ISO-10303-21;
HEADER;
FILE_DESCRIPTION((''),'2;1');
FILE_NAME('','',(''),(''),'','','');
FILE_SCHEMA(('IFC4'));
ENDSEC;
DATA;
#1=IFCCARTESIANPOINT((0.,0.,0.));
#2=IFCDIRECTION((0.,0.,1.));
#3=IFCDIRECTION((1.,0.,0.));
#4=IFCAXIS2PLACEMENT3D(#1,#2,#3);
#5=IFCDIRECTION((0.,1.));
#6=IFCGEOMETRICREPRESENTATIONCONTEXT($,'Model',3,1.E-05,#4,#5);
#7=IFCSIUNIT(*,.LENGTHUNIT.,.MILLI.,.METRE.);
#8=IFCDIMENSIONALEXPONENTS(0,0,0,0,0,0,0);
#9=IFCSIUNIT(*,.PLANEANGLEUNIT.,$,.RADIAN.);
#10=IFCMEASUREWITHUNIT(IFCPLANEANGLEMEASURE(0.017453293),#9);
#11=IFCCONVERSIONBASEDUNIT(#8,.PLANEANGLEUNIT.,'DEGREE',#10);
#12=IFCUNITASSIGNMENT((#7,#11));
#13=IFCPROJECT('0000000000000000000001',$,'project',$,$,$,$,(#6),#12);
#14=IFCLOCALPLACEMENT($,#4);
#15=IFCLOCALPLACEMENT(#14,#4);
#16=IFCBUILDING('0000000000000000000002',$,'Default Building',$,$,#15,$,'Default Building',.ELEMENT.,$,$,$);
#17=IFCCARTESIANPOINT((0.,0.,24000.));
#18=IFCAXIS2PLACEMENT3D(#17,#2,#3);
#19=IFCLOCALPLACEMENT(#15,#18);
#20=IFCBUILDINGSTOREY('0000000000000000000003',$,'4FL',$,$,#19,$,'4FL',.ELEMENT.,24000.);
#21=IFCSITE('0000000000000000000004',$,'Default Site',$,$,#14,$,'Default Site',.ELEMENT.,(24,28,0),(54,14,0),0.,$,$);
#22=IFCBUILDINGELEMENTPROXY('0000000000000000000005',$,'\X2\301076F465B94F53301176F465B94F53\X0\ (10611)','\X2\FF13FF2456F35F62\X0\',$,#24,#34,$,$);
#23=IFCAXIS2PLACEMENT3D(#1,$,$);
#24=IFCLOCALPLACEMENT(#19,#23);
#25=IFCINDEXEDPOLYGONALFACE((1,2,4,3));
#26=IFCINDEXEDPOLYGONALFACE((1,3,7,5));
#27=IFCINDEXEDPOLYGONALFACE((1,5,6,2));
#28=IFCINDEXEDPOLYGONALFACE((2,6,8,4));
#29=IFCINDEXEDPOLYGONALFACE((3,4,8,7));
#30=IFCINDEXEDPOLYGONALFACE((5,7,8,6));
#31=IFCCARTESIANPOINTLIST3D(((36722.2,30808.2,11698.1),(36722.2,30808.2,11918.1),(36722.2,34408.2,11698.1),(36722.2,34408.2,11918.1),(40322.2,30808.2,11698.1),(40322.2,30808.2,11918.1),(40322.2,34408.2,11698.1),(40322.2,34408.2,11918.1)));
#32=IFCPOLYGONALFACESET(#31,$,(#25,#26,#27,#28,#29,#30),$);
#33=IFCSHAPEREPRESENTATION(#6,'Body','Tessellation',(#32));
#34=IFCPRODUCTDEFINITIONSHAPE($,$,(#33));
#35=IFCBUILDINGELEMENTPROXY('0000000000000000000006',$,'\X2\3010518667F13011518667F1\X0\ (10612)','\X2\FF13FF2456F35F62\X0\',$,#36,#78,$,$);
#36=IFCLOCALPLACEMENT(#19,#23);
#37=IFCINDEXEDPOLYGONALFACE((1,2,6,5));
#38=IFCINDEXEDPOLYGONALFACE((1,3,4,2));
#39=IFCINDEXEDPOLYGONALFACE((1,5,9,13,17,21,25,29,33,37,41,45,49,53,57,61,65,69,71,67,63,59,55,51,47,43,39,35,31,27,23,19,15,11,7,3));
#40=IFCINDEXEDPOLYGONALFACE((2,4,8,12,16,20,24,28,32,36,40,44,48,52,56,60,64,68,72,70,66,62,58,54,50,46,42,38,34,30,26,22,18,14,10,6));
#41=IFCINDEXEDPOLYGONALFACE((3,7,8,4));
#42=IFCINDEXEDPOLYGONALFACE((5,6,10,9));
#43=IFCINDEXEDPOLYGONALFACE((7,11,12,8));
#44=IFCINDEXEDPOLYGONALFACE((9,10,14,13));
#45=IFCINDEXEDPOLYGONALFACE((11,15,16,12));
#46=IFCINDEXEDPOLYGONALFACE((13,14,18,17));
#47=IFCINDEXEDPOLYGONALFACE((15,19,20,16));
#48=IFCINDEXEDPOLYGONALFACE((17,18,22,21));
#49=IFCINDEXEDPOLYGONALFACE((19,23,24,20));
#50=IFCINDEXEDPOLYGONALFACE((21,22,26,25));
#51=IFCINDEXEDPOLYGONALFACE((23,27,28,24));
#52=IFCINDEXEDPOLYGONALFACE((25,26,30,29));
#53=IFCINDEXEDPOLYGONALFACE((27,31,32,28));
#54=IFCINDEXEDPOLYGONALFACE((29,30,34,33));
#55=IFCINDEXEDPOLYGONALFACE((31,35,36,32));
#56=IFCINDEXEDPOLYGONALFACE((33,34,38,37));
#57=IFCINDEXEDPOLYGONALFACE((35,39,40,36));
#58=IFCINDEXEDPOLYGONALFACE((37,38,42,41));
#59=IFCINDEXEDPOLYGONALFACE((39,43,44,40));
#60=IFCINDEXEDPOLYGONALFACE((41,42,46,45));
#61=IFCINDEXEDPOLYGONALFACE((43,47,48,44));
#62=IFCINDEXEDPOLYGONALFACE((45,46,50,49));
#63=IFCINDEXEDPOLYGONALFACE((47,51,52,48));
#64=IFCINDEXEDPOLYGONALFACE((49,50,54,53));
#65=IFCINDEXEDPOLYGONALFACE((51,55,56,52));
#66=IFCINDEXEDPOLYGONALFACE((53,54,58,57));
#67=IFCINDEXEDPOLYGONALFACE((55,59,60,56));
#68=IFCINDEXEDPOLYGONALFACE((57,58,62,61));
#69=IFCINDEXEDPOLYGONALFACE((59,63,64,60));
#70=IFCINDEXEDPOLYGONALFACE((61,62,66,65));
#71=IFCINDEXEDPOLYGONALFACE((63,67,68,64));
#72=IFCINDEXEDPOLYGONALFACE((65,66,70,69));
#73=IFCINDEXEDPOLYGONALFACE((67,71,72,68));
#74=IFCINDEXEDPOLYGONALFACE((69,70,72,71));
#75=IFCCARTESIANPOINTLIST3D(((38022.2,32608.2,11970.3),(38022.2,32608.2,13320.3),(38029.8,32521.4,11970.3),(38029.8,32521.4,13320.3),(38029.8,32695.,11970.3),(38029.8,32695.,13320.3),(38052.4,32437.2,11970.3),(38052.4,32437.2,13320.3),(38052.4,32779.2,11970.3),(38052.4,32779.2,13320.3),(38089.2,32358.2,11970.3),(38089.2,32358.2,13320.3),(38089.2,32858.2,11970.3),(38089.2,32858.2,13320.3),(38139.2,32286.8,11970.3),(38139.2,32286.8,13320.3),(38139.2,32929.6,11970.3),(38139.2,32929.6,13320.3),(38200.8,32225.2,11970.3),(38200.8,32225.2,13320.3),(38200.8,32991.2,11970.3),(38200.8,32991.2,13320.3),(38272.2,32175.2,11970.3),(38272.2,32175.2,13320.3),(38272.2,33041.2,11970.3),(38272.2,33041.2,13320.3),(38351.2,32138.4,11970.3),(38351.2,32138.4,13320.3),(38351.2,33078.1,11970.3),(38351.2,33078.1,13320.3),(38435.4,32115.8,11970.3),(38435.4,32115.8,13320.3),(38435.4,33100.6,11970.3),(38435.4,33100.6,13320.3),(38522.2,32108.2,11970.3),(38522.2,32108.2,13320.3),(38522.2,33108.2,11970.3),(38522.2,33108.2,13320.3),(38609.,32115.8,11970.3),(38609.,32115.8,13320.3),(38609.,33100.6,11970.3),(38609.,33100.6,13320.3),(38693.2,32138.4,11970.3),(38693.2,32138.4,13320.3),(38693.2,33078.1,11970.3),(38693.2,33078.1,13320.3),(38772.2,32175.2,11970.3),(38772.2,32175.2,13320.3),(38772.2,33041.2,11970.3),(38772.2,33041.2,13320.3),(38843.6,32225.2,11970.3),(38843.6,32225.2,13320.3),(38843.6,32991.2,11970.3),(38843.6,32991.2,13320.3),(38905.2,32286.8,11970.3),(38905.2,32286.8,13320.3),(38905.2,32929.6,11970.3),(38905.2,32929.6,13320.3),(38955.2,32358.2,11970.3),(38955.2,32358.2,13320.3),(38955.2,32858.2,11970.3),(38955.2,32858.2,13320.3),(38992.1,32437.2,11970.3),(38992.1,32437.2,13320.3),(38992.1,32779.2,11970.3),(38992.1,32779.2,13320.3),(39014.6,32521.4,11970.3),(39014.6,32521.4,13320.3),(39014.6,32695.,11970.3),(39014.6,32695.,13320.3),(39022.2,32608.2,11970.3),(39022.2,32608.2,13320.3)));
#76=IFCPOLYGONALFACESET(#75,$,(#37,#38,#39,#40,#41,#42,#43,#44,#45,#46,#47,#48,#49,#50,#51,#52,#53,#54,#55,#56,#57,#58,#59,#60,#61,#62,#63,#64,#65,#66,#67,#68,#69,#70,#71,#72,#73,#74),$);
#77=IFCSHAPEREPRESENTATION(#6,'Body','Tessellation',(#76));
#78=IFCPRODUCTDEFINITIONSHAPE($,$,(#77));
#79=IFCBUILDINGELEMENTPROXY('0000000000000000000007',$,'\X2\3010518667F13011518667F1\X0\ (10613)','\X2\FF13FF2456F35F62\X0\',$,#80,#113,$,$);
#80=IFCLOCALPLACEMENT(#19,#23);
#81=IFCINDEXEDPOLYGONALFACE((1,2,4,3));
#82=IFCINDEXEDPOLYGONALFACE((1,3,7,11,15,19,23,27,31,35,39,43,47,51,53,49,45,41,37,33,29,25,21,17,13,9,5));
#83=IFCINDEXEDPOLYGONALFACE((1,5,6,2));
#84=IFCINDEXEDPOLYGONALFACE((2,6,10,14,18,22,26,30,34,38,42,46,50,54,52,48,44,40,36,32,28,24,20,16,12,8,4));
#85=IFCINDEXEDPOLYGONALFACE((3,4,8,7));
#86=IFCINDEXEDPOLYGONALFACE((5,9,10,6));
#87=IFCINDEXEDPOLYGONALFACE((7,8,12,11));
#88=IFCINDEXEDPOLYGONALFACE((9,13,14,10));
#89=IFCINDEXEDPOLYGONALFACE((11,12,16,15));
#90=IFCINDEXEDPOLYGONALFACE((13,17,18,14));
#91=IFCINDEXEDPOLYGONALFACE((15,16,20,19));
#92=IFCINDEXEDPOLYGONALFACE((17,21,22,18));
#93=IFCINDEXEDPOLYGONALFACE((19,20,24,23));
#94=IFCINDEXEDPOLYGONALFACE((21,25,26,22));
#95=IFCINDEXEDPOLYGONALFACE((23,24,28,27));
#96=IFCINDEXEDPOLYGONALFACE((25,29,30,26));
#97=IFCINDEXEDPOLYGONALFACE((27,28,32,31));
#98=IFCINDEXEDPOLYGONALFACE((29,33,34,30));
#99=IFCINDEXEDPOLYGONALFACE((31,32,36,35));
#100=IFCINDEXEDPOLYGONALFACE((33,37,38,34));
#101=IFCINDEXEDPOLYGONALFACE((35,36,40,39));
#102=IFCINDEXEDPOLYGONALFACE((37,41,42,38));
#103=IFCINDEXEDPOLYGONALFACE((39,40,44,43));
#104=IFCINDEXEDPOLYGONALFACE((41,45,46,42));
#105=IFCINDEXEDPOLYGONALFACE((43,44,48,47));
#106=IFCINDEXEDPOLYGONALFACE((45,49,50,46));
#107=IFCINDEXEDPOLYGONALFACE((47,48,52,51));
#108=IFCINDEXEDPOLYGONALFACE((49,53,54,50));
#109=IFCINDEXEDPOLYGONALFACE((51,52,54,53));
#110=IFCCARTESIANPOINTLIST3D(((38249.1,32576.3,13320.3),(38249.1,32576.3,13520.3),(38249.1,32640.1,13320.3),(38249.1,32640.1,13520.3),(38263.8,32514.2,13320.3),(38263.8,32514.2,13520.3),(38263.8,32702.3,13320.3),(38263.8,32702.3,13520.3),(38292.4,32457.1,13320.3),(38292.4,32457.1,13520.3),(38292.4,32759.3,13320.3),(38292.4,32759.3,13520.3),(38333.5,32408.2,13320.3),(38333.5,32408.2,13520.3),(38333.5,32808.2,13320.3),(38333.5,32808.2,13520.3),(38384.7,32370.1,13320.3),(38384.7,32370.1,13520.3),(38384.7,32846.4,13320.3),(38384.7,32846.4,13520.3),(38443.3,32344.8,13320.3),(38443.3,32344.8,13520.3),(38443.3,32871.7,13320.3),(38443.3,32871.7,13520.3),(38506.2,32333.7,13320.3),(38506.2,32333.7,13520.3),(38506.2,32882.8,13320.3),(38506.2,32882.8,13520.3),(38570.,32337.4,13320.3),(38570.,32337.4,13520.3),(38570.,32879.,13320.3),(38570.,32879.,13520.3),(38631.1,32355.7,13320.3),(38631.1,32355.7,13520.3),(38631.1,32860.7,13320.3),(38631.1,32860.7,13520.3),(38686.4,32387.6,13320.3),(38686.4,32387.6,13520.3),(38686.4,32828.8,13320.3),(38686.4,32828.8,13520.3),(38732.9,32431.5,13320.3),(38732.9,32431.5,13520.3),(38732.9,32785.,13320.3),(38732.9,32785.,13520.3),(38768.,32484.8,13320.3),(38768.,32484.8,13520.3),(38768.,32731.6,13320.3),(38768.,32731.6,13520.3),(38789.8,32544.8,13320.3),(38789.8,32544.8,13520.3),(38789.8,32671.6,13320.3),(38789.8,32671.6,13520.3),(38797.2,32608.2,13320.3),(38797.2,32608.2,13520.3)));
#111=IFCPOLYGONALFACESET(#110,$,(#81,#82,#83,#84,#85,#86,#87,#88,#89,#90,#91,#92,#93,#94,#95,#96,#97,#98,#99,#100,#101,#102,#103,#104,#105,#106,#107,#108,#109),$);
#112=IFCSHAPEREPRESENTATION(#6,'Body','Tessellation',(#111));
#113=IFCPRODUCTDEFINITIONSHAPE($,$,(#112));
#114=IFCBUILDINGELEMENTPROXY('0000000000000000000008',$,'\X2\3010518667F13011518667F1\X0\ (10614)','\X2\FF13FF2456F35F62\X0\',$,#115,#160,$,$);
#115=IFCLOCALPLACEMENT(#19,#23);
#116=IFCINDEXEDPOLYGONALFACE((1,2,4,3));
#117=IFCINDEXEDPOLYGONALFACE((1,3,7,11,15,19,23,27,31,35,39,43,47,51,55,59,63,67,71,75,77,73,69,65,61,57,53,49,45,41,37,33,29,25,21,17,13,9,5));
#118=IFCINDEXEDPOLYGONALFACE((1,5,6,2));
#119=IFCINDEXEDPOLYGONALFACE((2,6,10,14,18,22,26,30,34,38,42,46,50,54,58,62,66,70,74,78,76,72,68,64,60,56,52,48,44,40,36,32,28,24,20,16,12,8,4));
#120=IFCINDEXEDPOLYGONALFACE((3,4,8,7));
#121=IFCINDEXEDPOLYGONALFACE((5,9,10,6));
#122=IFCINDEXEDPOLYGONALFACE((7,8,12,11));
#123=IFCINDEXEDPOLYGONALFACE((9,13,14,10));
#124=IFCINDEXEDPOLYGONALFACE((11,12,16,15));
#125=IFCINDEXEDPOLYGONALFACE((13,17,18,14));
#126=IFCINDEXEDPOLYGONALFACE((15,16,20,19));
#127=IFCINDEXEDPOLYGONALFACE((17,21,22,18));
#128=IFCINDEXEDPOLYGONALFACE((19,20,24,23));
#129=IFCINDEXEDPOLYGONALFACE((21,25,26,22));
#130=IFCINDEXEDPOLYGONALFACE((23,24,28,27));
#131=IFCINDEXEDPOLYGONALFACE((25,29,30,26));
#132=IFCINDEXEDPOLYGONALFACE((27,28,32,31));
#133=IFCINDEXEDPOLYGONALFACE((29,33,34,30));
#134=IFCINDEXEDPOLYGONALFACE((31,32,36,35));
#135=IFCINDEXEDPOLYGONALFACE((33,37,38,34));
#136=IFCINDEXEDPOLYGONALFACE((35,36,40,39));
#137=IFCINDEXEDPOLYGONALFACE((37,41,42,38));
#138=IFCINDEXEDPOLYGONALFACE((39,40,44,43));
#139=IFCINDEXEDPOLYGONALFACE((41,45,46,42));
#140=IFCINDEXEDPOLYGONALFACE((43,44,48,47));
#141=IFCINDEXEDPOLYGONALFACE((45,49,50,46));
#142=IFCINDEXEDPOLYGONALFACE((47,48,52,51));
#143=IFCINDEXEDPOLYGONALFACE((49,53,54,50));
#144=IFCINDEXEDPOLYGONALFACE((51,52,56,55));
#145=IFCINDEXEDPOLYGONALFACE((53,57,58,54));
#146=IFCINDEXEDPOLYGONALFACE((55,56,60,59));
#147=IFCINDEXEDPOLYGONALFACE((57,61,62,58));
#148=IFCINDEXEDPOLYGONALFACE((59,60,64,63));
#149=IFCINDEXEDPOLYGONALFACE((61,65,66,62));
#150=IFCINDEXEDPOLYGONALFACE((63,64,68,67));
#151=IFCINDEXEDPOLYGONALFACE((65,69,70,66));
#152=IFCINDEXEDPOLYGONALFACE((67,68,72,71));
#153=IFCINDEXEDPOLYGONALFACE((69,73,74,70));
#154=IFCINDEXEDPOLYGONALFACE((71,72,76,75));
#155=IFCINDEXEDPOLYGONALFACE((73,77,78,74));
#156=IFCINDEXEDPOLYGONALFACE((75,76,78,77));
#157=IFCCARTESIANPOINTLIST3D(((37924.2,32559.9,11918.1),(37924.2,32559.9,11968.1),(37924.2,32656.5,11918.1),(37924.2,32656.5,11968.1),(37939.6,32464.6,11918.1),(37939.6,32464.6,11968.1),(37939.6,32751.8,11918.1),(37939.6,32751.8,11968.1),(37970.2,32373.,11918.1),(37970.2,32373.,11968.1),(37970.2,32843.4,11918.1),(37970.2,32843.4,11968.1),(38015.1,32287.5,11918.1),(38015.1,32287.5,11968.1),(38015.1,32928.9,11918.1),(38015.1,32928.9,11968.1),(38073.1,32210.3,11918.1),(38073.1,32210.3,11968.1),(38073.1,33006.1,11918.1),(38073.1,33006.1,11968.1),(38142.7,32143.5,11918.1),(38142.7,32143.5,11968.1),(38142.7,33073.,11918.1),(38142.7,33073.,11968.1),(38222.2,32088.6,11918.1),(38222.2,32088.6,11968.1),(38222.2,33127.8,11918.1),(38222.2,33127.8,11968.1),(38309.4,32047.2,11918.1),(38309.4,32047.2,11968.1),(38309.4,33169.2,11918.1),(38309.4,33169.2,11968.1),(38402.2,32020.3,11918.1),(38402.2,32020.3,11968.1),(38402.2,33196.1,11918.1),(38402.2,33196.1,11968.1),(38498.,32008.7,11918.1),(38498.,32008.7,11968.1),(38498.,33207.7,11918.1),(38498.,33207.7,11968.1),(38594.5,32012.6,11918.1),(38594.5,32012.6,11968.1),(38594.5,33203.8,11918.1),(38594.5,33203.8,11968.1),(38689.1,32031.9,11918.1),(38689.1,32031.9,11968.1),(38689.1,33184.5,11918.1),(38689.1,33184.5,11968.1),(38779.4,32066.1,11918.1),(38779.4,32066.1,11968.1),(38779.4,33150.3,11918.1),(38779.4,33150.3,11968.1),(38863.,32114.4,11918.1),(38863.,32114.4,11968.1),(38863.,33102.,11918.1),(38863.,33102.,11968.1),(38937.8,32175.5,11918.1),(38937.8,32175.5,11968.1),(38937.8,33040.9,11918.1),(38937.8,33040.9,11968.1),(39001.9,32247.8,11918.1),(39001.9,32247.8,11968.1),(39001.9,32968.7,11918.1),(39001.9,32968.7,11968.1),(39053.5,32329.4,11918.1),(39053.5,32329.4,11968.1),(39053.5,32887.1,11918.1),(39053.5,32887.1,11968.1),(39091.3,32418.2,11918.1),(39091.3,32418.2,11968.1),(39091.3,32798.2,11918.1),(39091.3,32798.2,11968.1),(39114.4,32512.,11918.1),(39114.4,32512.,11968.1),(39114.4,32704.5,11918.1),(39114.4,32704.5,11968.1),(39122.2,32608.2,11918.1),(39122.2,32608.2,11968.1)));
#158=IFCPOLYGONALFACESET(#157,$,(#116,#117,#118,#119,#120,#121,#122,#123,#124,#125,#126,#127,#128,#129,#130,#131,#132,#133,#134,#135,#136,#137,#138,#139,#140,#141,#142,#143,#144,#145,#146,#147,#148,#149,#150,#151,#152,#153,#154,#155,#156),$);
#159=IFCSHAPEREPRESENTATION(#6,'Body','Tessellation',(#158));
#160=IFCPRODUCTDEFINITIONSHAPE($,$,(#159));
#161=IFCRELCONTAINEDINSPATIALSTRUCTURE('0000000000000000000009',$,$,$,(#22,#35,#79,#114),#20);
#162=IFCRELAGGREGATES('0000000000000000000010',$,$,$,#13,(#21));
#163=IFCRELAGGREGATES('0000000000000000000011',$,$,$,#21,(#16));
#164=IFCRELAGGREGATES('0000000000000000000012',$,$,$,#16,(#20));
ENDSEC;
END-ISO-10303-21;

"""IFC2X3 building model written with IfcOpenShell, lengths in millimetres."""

from ifc_helpers import new_model, entity, si_unit, converted_unit, direction, frame, origin_with_axes, origin_2d_with_axis, place, context, project, spatial, rectangle, circle, extrude, source, transform, mapped, element, save


model = new_model("IFC2X3")

# Units and contexts
model_context = context("Model", 3, precision=1e-05, world=origin_with_axes(), true_north=direction((0.0, 1.0)))
ifc_project = project(units=[si_unit("LENGTHUNIT", "METRE", prefix="MILLI"), converted_unit("PLANEANGLEUNIT", "DEGREE", entity("IfcPlaneAngleMeasure", 0.017453293), si_unit("PLANEANGLEUNIT", "RADIAN"), dimensions=[0, 0, 0, 0, 0, 0, 0])], contexts=[model_context])

# Site, building, storey
site_placement = place(None, origin_with_axes())
site = spatial("IfcSite", under=ifc_project, at=site_placement, Name="Default Site", LongName="Default Site", CompositionType="ELEMENT", RefLatitude=(24, 28, 0), RefLongitude=(54, 14, 0), RefElevation=0.0)
building_placement = place(site_placement, origin_with_axes())
building = spatial("IfcBuilding", under=site, at=building_placement, Name="Default Building", LongName="Default Building", CompositionType="ELEMENT")
storey_placement = place(building_placement, frame((0.0, 0.0, 24000.0), z_axis=(0.0, 0.0, 1.0), x_axis=(1.0, 0.0, 0.0)))
storey = spatial("IfcBuildingStorey", under=building, at=storey_placement, Name="4FL", LongName="4FL", CompositionType="ELEMENT", Elevation=24000.0)

# Building element proxies
shared_shape_1 = source(origin_with_axes(), model_context, "Body", "SweptSolid", [
    extrude(rectangle(XDim=3600.0, YDim=220.0, at=origin_2d_with_axis()), frame((0.0, 0.0, 0.0), z_axis=(0.0, 0.0, 1.0), x_axis=(1.0, 0.0, 0.0)), (0.0, 0.0, 1.0), 3600.0),
])
proxy_1_placement = place(storey_placement, frame((38522.2, 34408.2, 11808.1), z_axis=(0.0, -1.0, 0.0), x_axis=(1.0, 0.0, 0.0)))
element("IfcBuildingElementProxy", 1, at=proxy_1_placement, inside=storey, Name="【直方体】直方体 (10611)", Description="３Ｄ図形", context=model_context, shape_type="MappedRepresentation", body=[
    mapped(shared_shape_1, transform((0.0, 0.0, 0.0))),
])
shared_shape_2 = source(origin_with_axes(), model_context, "Body", "SweptSolid", [
    extrude(circle(Radius=500.0, at=origin_2d_with_axis()), origin_with_axes(), (0.0, 0.0, 1.0), 1350.0),
])
proxy_2_placement = place(storey_placement, frame((38522.2, 32608.2, 11970.3), z_axis=(0.0, 0.0, 1.0), x_axis=(1.0, 0.0, 0.0)))
element("IfcBuildingElementProxy", 2, at=proxy_2_placement, inside=storey, Name="【円柱】円柱 (10612)", Description="３Ｄ図形", context=model_context, shape_type="MappedRepresentation", body=[
    mapped(shared_shape_2, transform((0.0, 0.0, 0.0))),
])
shared_shape_3 = source(origin_with_axes(), model_context, "Body", "SweptSolid", [
    extrude(circle(Radius=275.0, at=origin_2d_with_axis()), frame((0.0, 0.0, 0.0), z_axis=(0.0, 0.0, 1.0), x_axis=(1.0, 0.0, 0.0)), (0.0, 0.0, 1.0), 200.0),
])
proxy_3_placement = place(storey_placement, frame((38522.2, 32608.2, 13320.3), z_axis=(0.0, 0.0, 1.0), x_axis=(1.0, 0.0, 0.0)))
element("IfcBuildingElementProxy", 3, at=proxy_3_placement, inside=storey, Name="【円柱】円柱 (10613)", Description="３Ｄ図形", context=model_context, shape_type="MappedRepresentation", body=[
    mapped(shared_shape_3, transform((0.0, 0.0, 0.0))),
])
shared_shape_4 = source(origin_with_axes(), model_context, "Body", "SweptSolid", [
    extrude(circle(Radius=600.0, at=origin_2d_with_axis()), origin_with_axes(), (0.0, 0.0, 1.0), 50.0),
])
proxy_4_placement = place(storey_placement, frame((38522.2, 32608.2, 11918.1), z_axis=(0.0, 0.0, 1.0), x_axis=(1.0, 0.0, 0.0)))
element("IfcBuildingElementProxy", 4, at=proxy_4_placement, inside=storey, Name="【円柱】円柱 (10614)", Description="３Ｄ図形", context=model_context, shape_type="MappedRepresentation", body=[
    mapped(shared_shape_4, transform((0.0, 0.0, 0.0))),
])

save(model, "model.ifc")
